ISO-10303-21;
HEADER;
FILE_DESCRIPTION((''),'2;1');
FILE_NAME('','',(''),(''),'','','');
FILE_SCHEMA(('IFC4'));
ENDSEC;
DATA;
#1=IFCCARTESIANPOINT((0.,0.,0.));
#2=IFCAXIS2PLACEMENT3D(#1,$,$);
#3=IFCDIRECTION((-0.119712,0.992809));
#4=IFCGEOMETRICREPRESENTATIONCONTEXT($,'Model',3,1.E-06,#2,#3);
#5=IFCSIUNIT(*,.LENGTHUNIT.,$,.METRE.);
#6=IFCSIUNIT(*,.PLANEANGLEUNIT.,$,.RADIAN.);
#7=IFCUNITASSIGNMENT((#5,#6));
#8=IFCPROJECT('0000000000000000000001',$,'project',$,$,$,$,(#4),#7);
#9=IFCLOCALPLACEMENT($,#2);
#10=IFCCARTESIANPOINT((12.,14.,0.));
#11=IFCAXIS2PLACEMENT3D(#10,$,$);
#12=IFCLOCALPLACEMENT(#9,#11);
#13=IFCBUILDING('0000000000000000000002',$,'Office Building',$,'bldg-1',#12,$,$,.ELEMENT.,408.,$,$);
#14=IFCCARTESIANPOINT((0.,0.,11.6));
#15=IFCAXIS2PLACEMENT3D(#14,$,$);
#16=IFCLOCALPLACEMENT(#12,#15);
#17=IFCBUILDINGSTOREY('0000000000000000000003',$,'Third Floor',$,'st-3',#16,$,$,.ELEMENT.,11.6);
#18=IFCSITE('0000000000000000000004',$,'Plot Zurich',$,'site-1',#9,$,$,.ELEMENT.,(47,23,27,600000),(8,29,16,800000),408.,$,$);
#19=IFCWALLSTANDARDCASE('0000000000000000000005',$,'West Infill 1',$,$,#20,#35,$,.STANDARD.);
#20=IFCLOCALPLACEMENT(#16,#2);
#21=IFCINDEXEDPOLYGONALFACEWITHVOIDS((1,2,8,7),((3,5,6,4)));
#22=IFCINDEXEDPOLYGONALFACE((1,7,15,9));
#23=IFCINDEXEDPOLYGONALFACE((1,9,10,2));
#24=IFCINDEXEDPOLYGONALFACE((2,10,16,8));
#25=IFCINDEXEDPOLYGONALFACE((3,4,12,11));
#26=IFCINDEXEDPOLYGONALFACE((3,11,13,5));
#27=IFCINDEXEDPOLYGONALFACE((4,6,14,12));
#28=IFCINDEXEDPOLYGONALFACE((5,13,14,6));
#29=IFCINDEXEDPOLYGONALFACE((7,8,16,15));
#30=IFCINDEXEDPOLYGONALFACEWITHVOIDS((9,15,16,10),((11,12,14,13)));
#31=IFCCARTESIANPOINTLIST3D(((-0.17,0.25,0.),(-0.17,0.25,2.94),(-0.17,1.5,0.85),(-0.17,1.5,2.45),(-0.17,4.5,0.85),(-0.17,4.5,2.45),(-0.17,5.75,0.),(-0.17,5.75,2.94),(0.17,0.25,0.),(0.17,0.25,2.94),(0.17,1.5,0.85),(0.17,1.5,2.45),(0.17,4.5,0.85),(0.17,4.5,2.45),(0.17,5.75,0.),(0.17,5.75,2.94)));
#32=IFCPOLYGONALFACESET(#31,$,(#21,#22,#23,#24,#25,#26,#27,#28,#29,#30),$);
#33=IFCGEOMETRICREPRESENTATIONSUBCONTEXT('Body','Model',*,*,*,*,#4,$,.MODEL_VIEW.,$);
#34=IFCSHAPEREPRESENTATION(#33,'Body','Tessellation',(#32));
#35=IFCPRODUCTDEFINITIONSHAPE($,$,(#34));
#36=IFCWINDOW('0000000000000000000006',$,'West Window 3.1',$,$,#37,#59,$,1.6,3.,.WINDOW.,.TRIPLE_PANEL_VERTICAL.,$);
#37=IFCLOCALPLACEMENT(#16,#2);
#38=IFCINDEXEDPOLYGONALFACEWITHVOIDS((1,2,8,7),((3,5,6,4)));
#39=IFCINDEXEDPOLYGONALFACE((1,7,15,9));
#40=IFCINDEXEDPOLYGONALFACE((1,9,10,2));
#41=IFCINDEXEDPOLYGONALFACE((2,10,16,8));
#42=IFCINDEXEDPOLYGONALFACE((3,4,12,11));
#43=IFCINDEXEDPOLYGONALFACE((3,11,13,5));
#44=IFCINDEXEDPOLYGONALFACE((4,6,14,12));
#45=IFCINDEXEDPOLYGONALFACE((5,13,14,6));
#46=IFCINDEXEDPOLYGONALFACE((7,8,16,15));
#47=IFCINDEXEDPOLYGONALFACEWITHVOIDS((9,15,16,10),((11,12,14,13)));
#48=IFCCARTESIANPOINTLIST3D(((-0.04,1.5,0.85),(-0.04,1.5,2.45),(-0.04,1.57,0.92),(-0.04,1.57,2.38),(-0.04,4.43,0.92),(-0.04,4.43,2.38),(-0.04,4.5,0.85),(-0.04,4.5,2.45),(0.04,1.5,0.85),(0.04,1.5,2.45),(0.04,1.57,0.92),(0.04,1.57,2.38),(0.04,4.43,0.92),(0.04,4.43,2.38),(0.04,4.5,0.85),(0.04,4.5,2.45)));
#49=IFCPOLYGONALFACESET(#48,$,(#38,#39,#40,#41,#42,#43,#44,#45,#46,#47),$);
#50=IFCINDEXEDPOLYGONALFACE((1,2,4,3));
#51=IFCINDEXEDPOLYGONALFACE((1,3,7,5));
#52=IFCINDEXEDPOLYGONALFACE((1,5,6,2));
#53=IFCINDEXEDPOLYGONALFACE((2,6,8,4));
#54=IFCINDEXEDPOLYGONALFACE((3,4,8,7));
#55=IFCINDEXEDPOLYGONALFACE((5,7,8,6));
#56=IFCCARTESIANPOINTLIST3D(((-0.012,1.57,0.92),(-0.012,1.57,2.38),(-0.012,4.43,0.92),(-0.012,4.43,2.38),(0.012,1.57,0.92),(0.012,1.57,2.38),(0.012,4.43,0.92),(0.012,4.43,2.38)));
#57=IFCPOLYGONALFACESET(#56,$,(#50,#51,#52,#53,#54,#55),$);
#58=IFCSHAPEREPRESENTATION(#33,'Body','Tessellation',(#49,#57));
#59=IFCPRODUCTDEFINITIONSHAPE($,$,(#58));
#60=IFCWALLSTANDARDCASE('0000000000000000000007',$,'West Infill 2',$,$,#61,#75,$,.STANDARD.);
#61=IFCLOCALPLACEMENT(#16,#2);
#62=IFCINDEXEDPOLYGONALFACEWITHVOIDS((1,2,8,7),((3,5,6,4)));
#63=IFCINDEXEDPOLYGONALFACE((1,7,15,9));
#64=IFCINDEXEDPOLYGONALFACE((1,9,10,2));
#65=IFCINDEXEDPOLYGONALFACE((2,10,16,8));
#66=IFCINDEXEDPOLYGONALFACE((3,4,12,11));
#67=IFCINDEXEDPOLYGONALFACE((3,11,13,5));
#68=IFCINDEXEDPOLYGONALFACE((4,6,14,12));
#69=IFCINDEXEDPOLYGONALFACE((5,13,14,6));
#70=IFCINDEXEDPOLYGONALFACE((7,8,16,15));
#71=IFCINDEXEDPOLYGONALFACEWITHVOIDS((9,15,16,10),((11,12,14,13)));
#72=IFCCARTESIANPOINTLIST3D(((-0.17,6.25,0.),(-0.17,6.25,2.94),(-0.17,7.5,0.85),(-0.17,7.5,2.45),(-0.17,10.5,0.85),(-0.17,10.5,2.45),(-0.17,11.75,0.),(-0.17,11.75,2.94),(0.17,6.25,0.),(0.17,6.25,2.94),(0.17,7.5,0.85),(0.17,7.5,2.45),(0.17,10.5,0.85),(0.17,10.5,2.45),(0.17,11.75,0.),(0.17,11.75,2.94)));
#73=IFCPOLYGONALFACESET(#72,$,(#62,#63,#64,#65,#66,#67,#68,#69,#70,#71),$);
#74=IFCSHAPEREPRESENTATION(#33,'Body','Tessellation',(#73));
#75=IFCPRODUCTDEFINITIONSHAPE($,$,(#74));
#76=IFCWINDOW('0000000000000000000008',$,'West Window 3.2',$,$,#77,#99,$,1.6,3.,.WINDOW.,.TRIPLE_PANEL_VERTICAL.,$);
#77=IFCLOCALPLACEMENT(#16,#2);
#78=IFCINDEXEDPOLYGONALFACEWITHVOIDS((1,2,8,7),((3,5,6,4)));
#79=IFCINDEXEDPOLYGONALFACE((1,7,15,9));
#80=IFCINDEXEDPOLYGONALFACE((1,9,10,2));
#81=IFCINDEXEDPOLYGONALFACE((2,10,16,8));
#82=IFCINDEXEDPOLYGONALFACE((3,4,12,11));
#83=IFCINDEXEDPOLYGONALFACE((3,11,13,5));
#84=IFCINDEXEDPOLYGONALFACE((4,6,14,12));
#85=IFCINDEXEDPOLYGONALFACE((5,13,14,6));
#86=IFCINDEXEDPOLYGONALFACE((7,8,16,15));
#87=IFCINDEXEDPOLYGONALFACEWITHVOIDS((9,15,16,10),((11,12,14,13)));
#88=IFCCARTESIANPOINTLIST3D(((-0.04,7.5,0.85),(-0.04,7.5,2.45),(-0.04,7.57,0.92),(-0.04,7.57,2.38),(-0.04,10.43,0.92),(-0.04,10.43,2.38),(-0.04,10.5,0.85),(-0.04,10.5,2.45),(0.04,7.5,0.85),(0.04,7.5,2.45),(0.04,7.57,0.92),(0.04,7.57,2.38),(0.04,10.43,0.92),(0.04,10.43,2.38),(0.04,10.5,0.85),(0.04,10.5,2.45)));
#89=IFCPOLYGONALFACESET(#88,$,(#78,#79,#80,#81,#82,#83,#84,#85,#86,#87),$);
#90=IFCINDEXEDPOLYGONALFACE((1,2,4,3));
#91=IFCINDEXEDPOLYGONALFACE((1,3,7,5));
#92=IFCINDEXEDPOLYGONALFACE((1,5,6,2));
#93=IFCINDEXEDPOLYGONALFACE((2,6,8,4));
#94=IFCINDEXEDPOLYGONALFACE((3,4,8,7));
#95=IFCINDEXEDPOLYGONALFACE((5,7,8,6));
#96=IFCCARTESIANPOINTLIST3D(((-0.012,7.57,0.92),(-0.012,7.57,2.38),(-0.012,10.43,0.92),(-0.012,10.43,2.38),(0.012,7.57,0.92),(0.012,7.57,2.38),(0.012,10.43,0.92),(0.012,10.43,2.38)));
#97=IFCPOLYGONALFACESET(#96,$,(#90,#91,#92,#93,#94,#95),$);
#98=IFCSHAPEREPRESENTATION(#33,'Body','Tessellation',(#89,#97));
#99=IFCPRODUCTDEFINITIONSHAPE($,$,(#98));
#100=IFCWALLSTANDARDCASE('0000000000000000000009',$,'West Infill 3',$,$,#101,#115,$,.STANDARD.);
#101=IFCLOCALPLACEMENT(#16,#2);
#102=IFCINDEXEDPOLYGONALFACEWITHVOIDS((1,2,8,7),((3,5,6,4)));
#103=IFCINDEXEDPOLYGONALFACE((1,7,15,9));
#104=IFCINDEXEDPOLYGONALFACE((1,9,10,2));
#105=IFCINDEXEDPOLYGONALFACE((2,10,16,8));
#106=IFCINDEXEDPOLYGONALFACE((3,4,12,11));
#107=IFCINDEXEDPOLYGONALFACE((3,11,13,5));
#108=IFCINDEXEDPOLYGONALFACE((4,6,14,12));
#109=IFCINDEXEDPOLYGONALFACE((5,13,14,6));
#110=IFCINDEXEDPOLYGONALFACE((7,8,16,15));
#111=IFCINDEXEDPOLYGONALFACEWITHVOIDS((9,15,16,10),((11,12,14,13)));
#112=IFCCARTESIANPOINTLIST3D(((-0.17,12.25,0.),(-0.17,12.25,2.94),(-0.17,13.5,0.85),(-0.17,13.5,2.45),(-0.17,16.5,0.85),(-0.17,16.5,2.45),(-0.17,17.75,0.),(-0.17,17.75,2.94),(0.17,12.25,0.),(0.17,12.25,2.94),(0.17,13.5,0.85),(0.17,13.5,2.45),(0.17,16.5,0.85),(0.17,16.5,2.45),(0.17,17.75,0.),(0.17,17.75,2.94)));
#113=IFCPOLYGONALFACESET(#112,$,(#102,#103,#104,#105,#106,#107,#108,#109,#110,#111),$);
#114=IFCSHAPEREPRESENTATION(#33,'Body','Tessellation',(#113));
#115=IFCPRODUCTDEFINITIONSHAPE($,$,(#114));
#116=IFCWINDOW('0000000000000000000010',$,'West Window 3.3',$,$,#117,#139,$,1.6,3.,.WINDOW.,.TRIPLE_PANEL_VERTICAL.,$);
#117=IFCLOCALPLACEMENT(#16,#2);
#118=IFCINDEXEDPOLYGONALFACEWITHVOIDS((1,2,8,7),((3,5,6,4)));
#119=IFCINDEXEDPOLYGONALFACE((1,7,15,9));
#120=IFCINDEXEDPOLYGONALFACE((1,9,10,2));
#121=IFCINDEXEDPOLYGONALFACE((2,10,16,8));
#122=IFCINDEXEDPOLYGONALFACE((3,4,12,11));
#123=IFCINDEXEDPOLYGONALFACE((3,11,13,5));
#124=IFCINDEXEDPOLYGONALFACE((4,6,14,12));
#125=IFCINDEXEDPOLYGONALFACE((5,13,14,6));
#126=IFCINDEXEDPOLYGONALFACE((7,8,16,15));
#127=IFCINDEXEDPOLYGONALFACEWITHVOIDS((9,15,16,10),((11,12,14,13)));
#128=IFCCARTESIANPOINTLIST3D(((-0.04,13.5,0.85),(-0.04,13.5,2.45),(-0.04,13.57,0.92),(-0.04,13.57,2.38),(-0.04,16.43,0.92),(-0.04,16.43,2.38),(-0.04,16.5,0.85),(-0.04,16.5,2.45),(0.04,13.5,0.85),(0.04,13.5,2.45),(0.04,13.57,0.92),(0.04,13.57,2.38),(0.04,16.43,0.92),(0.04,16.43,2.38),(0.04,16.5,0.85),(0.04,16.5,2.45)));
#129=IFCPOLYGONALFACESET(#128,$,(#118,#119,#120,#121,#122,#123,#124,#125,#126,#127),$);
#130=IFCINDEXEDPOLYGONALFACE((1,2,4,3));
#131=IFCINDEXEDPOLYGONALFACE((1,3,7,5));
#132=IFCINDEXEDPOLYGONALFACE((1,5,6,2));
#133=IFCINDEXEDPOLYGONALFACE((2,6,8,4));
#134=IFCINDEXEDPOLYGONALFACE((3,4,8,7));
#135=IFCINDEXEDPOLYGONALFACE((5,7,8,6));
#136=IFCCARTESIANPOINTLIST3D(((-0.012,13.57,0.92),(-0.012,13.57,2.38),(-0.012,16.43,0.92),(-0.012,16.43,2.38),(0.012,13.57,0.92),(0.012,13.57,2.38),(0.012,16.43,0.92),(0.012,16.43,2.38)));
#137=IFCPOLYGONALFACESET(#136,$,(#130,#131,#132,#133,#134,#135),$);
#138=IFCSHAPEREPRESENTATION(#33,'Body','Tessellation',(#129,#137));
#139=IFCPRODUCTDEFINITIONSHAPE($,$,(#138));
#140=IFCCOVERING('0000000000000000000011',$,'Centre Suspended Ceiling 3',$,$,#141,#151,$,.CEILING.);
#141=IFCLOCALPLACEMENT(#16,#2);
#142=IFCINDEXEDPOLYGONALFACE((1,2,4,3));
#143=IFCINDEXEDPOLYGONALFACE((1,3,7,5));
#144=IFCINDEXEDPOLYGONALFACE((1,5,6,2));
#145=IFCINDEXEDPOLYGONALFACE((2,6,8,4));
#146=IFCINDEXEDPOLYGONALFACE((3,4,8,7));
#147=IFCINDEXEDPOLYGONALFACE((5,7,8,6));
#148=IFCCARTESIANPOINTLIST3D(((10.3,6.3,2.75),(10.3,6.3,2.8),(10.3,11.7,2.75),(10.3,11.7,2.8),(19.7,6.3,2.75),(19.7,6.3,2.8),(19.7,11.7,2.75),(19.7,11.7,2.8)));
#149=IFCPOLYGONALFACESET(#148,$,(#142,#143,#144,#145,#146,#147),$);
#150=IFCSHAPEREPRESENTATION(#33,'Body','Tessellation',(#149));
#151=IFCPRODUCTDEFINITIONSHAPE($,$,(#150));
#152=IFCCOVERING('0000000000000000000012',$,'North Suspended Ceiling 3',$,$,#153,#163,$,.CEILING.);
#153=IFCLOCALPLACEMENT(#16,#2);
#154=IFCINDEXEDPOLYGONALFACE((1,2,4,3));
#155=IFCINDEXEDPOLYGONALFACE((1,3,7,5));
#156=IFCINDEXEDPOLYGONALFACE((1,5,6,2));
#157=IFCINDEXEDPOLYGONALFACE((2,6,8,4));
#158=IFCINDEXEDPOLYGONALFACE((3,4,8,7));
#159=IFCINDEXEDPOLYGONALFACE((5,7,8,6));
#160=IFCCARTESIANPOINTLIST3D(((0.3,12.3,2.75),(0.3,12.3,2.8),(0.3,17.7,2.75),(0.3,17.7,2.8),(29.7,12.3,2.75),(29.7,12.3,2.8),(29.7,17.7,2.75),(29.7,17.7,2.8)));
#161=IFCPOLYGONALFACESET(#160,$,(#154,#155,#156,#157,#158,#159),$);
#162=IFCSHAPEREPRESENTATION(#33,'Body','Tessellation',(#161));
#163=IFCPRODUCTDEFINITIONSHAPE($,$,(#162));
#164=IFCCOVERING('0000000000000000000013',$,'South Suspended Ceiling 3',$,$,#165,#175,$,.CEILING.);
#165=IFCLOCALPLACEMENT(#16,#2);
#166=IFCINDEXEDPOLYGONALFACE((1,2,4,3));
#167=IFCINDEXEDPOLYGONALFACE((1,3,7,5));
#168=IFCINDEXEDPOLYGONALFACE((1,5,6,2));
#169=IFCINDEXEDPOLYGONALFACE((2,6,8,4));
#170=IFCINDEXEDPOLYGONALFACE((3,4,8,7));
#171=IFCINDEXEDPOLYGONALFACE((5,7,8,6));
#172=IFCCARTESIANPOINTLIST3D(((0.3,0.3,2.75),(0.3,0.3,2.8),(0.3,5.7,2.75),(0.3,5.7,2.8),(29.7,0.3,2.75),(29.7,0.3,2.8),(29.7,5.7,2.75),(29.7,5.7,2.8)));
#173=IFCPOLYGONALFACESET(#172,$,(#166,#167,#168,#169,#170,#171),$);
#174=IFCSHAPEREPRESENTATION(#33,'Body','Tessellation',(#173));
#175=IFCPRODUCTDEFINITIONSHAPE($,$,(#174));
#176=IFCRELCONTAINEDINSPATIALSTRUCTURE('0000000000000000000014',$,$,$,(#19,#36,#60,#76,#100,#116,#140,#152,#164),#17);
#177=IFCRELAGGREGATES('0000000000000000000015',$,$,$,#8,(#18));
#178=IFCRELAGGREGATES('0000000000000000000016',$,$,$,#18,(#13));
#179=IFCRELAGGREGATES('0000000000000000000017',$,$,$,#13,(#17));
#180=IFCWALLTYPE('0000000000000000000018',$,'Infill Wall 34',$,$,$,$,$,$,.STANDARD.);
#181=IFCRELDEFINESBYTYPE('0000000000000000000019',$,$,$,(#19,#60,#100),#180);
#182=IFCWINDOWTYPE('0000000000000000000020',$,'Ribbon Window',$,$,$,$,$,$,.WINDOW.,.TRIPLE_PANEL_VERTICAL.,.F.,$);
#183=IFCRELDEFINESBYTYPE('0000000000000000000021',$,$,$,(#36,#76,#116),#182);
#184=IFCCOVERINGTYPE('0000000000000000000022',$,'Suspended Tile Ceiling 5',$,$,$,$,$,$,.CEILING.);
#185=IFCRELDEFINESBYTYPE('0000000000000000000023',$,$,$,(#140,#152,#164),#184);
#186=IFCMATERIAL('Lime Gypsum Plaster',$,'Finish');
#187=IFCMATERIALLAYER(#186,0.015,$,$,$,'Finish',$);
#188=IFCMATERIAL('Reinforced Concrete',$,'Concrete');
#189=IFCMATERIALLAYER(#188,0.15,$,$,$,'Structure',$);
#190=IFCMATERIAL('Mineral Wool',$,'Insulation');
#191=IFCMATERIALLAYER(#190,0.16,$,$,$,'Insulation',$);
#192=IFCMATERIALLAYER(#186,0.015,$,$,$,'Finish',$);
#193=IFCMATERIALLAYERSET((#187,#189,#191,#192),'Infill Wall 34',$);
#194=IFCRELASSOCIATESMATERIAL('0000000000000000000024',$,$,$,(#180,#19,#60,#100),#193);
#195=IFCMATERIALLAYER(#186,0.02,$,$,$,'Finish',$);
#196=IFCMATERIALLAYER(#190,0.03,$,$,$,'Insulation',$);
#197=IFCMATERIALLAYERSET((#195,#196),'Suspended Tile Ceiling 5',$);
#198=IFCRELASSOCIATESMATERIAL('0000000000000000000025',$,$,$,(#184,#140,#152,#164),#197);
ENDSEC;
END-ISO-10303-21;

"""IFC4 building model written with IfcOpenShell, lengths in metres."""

from ifc_helpers import new_model, si_unit, direction, frame, frame_2d, origin, origin_2d, place, context, subcontext, project, spatial, polyline, rectangle, outline, extrude, material, layer, layer_set, layer_usage, type_object, element, fill, save


model = new_model("IFC4")

# Units and contexts
model_context = context("Model", 3, precision=1e-06, world=origin(), true_north=direction((-0.119712, 0.992809)))
body_context = subcontext(model_context, "Body", "Model", "MODEL_VIEW")
ifc_project = project(units=[si_unit("LENGTHUNIT", "METRE"), si_unit("PLANEANGLEUNIT", "RADIAN")], contexts=[model_context])

# Site, building, storey
site_placement = place(None, origin())
site = spatial("IfcSite", under=ifc_project, at=site_placement, Name="Plot Zurich", ObjectType="site-1", CompositionType="ELEMENT", RefLatitude=(47, 23, 27, 600000), RefLongitude=(8, 29, 16, 800000), RefElevation=408.0)
building_placement = place(site_placement, frame((12.0, 14.0, 0.0)))
building = spatial("IfcBuilding", under=site, at=building_placement, Name="Office Building", ObjectType="bldg-1", CompositionType="ELEMENT", ElevationOfRefHeight=408.0)
storey_placement = place(building_placement, frame((0.0, 0.0, 11.6)))
storey = spatial("IfcBuildingStorey", under=building, at=storey_placement, Name="Third Floor", ObjectType="st-3", CompositionType="ELEMENT", Elevation=11.6)

# Shared definitions
ifc_material_1 = material(Name="Reinforced Concrete", Category="Concrete")

# Walls, openings, windows
ifc_material_2 = material(Name="Lime Gypsum Plaster", Category="Finish")
ifc_layer_1 = layer(ifc_material_2, 0.015, Category="Finish")
ifc_layer_2 = layer(ifc_material_1, 0.15, Category="Structure")
ifc_material_3 = material(Name="Mineral Wool", Category="Insulation")
ifc_layer_3 = layer(ifc_material_3, 0.16, Category="Insulation")
ifc_layer_4 = layer(ifc_material_2, 0.015, Category="Finish")
ifc_layer_set_1 = layer_set([ifc_layer_1, ifc_layer_2, ifc_layer_3, ifc_layer_4], Name="Infill Wall 34")
ifc_layer_usage_1 = layer_usage(ifc_layer_set_1, "AXIS2", "NEGATIVE", 0.17)
wall_type_1 = type_object("IfcWallType", Name="Infill Wall 34", PredefinedType="STANDARD", material=ifc_layer_set_1)
wall_1_placement = place(storey_placement, frame((0.0, 5.75, 0.0), z_axis=(0.0, 0.0, 1.0), x_axis=(0.0, -1.0, 0.0)))
wall_1 = element("IfcWallStandardCase", 1, at=wall_1_placement, inside=storey, type_object=wall_type_1, material=ifc_layer_usage_1, Name="West Infill 1", PredefinedType="STANDARD", context=body_context, shape_type="SweptSolid", body=[
    extrude(rectangle(XDim=5.5, YDim=0.34, at=frame_2d((2.75, 0.0))), origin(), (0.0, 0.0, 1.0), 2.94),
])
opening_1_placement = place(wall_1_placement, frame((2.75, 0.0, 0.85)))
opening_1 = element("IfcOpeningElement", 2, at=opening_1_placement, cuts=wall_1, PredefinedType="OPENING", context=body_context, shape_type="SweptSolid", body=[
    extrude(rectangle(XDim=3.0, YDim=0.34, at=origin_2d()), origin(), (0.0, 0.0, 1.0), 1.6),
])
window_type = type_object("IfcWindowType", Name="Ribbon Window", ParameterTakesPrecedence=False, PartitioningType="TRIPLE_PANEL_VERTICAL", PredefinedType="WINDOW")
window_1_placement = place(opening_1_placement, frame((0.0, 0.0, 0.0), z_axis=(0.0, -1.0, 0.0), x_axis=(1.0, 0.0, 0.0)))
window_1 = element("IfcWindow", 3, at=window_1_placement, inside=storey, type_object=window_type, Name="West Window 3.1", OverallHeight=1.6, OverallWidth=3.0, PartitioningType="TRIPLE_PANEL_VERTICAL", PredefinedType="WINDOW", context=body_context, shape_type="SweptSolid", body=[
    extrude(outline(polyline([(-1.5, 0.0), (1.5, 0.0), (1.5, 1.6), (-1.5, 1.6), (-1.5, 0.0)]), holes=[polyline([(-1.43, 0.07), (1.43, 0.07), (1.43, 1.53), (-1.43, 1.53), (-1.43, 0.07)])]), frame((0.0, 0.0, -0.04)), (0.0, 0.0, 1.0), 0.08),
    extrude(rectangle(XDim=2.86, YDim=1.46, at=frame_2d((0.0, 0.8))), frame((0.0, 0.0, -0.012)), (0.0, 0.0, 1.0), 0.024),
])
fill(opening_1, window_1)
ifc_layer_usage_2 = layer_usage(ifc_layer_set_1, "AXIS2", "NEGATIVE", 0.17)
wall_2_placement = place(storey_placement, frame((0.0, 11.75, 0.0), z_axis=(0.0, 0.0, 1.0), x_axis=(0.0, -1.0, 0.0)))
wall_2 = element("IfcWallStandardCase", 4, at=wall_2_placement, inside=storey, type_object=wall_type_1, material=ifc_layer_usage_2, Name="West Infill 2", PredefinedType="STANDARD", context=body_context, shape_type="SweptSolid", body=[
    extrude(rectangle(XDim=5.5, YDim=0.34, at=frame_2d((2.75, 0.0))), origin(), (0.0, 0.0, 1.0), 2.94),
])
opening_2_placement = place(wall_2_placement, frame((2.75, 0.0, 0.85)))
opening_2 = element("IfcOpeningElement", 5, at=opening_2_placement, cuts=wall_2, PredefinedType="OPENING", context=body_context, shape_type="SweptSolid", body=[
    extrude(rectangle(XDim=3.0, YDim=0.34, at=origin_2d()), origin(), (0.0, 0.0, 1.0), 1.6),
])
window_2_placement = place(opening_2_placement, frame((0.0, 0.0, 0.0), z_axis=(0.0, -1.0, 0.0), x_axis=(1.0, 0.0, 0.0)))
window_2 = element("IfcWindow", 6, at=window_2_placement, inside=storey, type_object=window_type, Name="West Window 3.2", OverallHeight=1.6, OverallWidth=3.0, PartitioningType="TRIPLE_PANEL_VERTICAL", PredefinedType="WINDOW", context=body_context, shape_type="SweptSolid", body=[
    extrude(outline(polyline([(-1.5, 0.0), (1.5, 0.0), (1.5, 1.6), (-1.5, 1.6), (-1.5, 0.0)]), holes=[polyline([(-1.43, 0.07), (1.43, 0.07), (1.43, 1.53), (-1.43, 1.53), (-1.43, 0.07)])]), frame((0.0, 0.0, -0.04)), (0.0, 0.0, 1.0), 0.08),
    extrude(rectangle(XDim=2.86, YDim=1.46, at=frame_2d((0.0, 0.8))), frame((0.0, 0.0, -0.012)), (0.0, 0.0, 1.0), 0.024),
])
fill(opening_2, window_2)
ifc_layer_usage_3 = layer_usage(ifc_layer_set_1, "AXIS2", "NEGATIVE", 0.17)
wall_3_placement = place(storey_placement, frame((0.0, 17.75, 0.0), z_axis=(0.0, 0.0, 1.0), x_axis=(0.0, -1.0, 0.0)))
wall_3 = element("IfcWallStandardCase", 7, at=wall_3_placement, inside=storey, type_object=wall_type_1, material=ifc_layer_usage_3, Name="West Infill 3", PredefinedType="STANDARD", context=body_context, shape_type="SweptSolid", body=[
    extrude(rectangle(XDim=5.5, YDim=0.34, at=frame_2d((2.75, 0.0))), origin(), (0.0, 0.0, 1.0), 2.94),
])
opening_3_placement = place(wall_3_placement, frame((2.75, 0.0, 0.85)))
opening_3 = element("IfcOpeningElement", 8, at=opening_3_placement, cuts=wall_3, PredefinedType="OPENING", context=body_context, shape_type="SweptSolid", body=[
    extrude(rectangle(XDim=3.0, YDim=0.34, at=origin_2d()), origin(), (0.0, 0.0, 1.0), 1.6),
])
window_3_placement = place(opening_3_placement, frame((0.0, 0.0, 0.0), z_axis=(0.0, -1.0, 0.0), x_axis=(1.0, 0.0, 0.0)))
window_3 = element("IfcWindow", 9, at=window_3_placement, inside=storey, type_object=window_type, Name="West Window 3.3", OverallHeight=1.6, OverallWidth=3.0, PartitioningType="TRIPLE_PANEL_VERTICAL", PredefinedType="WINDOW", context=body_context, shape_type="SweptSolid", body=[
    extrude(outline(polyline([(-1.5, 0.0), (1.5, 0.0), (1.5, 1.6), (-1.5, 1.6), (-1.5, 0.0)]), holes=[polyline([(-1.43, 0.07), (1.43, 0.07), (1.43, 1.53), (-1.43, 1.53), (-1.43, 0.07)])]), frame((0.0, 0.0, -0.04)), (0.0, 0.0, 1.0), 0.08),
    extrude(rectangle(XDim=2.86, YDim=1.46, at=frame_2d((0.0, 0.8))), frame((0.0, 0.0, -0.012)), (0.0, 0.0, 1.0), 0.024),
])
fill(opening_3, window_3)

# Coverings
ifc_layer_5 = layer(ifc_material_2, 0.02, Category="Finish")
ifc_layer_6 = layer(ifc_material_3, 0.03, Category="Insulation")
ifc_layer_set_2 = layer_set([ifc_layer_5, ifc_layer_6], Name="Suspended Tile Ceiling 5")
ifc_layer_usage_4 = layer_usage(ifc_layer_set_2, "AXIS3", "NEGATIVE", 0.05)
covering_type = type_object("IfcCoveringType", Name="Suspended Tile Ceiling 5", PredefinedType="CEILING", material=ifc_layer_set_2)
covering_1_placement = place(storey_placement, frame((0.0, 0.0, 2.75)))
element("IfcCovering", 10, at=covering_1_placement, inside=storey, type_object=covering_type, material=ifc_layer_usage_4, Name="Centre Suspended Ceiling 3", PredefinedType="CEILING", context=body_context, shape_type="SweptSolid", body=[
    extrude(outline(polyline([(10.3, 6.3), (19.7, 6.3), (19.7, 11.7), (10.3, 11.7), (10.3, 6.3)])), origin(), (0.0, 0.0, 1.0), 0.05),
])
ifc_layer_usage_5 = layer_usage(ifc_layer_set_2, "AXIS3", "NEGATIVE", 0.05)
covering_2_placement = place(storey_placement, frame((0.0, 0.0, 2.75)))
element("IfcCovering", 11, at=covering_2_placement, inside=storey, type_object=covering_type, material=ifc_layer_usage_5, Name="North Suspended Ceiling 3", PredefinedType="CEILING", context=body_context, shape_type="SweptSolid", body=[
    extrude(outline(polyline([(0.3, 12.3), (29.7, 12.3), (29.7, 17.7), (0.3, 17.7), (0.3, 12.3)])), origin(), (0.0, 0.0, 1.0), 0.05),
])
ifc_layer_usage_6 = layer_usage(ifc_layer_set_2, "AXIS3", "NEGATIVE", 0.05)
covering_3_placement = place(storey_placement, frame((0.0, 0.0, 2.75)))
element("IfcCovering", 12, at=covering_3_placement, inside=storey, type_object=covering_type, material=ifc_layer_usage_6, Name="South Suspended Ceiling 3", PredefinedType="CEILING", context=body_context, shape_type="SweptSolid", body=[
    extrude(outline(polyline([(0.3, 0.3), (29.7, 0.3), (29.7, 5.7), (0.3, 5.7), (0.3, 0.3)])), origin(), (0.0, 0.0, 1.0), 0.05),
])

save(model, "model.ifc")
